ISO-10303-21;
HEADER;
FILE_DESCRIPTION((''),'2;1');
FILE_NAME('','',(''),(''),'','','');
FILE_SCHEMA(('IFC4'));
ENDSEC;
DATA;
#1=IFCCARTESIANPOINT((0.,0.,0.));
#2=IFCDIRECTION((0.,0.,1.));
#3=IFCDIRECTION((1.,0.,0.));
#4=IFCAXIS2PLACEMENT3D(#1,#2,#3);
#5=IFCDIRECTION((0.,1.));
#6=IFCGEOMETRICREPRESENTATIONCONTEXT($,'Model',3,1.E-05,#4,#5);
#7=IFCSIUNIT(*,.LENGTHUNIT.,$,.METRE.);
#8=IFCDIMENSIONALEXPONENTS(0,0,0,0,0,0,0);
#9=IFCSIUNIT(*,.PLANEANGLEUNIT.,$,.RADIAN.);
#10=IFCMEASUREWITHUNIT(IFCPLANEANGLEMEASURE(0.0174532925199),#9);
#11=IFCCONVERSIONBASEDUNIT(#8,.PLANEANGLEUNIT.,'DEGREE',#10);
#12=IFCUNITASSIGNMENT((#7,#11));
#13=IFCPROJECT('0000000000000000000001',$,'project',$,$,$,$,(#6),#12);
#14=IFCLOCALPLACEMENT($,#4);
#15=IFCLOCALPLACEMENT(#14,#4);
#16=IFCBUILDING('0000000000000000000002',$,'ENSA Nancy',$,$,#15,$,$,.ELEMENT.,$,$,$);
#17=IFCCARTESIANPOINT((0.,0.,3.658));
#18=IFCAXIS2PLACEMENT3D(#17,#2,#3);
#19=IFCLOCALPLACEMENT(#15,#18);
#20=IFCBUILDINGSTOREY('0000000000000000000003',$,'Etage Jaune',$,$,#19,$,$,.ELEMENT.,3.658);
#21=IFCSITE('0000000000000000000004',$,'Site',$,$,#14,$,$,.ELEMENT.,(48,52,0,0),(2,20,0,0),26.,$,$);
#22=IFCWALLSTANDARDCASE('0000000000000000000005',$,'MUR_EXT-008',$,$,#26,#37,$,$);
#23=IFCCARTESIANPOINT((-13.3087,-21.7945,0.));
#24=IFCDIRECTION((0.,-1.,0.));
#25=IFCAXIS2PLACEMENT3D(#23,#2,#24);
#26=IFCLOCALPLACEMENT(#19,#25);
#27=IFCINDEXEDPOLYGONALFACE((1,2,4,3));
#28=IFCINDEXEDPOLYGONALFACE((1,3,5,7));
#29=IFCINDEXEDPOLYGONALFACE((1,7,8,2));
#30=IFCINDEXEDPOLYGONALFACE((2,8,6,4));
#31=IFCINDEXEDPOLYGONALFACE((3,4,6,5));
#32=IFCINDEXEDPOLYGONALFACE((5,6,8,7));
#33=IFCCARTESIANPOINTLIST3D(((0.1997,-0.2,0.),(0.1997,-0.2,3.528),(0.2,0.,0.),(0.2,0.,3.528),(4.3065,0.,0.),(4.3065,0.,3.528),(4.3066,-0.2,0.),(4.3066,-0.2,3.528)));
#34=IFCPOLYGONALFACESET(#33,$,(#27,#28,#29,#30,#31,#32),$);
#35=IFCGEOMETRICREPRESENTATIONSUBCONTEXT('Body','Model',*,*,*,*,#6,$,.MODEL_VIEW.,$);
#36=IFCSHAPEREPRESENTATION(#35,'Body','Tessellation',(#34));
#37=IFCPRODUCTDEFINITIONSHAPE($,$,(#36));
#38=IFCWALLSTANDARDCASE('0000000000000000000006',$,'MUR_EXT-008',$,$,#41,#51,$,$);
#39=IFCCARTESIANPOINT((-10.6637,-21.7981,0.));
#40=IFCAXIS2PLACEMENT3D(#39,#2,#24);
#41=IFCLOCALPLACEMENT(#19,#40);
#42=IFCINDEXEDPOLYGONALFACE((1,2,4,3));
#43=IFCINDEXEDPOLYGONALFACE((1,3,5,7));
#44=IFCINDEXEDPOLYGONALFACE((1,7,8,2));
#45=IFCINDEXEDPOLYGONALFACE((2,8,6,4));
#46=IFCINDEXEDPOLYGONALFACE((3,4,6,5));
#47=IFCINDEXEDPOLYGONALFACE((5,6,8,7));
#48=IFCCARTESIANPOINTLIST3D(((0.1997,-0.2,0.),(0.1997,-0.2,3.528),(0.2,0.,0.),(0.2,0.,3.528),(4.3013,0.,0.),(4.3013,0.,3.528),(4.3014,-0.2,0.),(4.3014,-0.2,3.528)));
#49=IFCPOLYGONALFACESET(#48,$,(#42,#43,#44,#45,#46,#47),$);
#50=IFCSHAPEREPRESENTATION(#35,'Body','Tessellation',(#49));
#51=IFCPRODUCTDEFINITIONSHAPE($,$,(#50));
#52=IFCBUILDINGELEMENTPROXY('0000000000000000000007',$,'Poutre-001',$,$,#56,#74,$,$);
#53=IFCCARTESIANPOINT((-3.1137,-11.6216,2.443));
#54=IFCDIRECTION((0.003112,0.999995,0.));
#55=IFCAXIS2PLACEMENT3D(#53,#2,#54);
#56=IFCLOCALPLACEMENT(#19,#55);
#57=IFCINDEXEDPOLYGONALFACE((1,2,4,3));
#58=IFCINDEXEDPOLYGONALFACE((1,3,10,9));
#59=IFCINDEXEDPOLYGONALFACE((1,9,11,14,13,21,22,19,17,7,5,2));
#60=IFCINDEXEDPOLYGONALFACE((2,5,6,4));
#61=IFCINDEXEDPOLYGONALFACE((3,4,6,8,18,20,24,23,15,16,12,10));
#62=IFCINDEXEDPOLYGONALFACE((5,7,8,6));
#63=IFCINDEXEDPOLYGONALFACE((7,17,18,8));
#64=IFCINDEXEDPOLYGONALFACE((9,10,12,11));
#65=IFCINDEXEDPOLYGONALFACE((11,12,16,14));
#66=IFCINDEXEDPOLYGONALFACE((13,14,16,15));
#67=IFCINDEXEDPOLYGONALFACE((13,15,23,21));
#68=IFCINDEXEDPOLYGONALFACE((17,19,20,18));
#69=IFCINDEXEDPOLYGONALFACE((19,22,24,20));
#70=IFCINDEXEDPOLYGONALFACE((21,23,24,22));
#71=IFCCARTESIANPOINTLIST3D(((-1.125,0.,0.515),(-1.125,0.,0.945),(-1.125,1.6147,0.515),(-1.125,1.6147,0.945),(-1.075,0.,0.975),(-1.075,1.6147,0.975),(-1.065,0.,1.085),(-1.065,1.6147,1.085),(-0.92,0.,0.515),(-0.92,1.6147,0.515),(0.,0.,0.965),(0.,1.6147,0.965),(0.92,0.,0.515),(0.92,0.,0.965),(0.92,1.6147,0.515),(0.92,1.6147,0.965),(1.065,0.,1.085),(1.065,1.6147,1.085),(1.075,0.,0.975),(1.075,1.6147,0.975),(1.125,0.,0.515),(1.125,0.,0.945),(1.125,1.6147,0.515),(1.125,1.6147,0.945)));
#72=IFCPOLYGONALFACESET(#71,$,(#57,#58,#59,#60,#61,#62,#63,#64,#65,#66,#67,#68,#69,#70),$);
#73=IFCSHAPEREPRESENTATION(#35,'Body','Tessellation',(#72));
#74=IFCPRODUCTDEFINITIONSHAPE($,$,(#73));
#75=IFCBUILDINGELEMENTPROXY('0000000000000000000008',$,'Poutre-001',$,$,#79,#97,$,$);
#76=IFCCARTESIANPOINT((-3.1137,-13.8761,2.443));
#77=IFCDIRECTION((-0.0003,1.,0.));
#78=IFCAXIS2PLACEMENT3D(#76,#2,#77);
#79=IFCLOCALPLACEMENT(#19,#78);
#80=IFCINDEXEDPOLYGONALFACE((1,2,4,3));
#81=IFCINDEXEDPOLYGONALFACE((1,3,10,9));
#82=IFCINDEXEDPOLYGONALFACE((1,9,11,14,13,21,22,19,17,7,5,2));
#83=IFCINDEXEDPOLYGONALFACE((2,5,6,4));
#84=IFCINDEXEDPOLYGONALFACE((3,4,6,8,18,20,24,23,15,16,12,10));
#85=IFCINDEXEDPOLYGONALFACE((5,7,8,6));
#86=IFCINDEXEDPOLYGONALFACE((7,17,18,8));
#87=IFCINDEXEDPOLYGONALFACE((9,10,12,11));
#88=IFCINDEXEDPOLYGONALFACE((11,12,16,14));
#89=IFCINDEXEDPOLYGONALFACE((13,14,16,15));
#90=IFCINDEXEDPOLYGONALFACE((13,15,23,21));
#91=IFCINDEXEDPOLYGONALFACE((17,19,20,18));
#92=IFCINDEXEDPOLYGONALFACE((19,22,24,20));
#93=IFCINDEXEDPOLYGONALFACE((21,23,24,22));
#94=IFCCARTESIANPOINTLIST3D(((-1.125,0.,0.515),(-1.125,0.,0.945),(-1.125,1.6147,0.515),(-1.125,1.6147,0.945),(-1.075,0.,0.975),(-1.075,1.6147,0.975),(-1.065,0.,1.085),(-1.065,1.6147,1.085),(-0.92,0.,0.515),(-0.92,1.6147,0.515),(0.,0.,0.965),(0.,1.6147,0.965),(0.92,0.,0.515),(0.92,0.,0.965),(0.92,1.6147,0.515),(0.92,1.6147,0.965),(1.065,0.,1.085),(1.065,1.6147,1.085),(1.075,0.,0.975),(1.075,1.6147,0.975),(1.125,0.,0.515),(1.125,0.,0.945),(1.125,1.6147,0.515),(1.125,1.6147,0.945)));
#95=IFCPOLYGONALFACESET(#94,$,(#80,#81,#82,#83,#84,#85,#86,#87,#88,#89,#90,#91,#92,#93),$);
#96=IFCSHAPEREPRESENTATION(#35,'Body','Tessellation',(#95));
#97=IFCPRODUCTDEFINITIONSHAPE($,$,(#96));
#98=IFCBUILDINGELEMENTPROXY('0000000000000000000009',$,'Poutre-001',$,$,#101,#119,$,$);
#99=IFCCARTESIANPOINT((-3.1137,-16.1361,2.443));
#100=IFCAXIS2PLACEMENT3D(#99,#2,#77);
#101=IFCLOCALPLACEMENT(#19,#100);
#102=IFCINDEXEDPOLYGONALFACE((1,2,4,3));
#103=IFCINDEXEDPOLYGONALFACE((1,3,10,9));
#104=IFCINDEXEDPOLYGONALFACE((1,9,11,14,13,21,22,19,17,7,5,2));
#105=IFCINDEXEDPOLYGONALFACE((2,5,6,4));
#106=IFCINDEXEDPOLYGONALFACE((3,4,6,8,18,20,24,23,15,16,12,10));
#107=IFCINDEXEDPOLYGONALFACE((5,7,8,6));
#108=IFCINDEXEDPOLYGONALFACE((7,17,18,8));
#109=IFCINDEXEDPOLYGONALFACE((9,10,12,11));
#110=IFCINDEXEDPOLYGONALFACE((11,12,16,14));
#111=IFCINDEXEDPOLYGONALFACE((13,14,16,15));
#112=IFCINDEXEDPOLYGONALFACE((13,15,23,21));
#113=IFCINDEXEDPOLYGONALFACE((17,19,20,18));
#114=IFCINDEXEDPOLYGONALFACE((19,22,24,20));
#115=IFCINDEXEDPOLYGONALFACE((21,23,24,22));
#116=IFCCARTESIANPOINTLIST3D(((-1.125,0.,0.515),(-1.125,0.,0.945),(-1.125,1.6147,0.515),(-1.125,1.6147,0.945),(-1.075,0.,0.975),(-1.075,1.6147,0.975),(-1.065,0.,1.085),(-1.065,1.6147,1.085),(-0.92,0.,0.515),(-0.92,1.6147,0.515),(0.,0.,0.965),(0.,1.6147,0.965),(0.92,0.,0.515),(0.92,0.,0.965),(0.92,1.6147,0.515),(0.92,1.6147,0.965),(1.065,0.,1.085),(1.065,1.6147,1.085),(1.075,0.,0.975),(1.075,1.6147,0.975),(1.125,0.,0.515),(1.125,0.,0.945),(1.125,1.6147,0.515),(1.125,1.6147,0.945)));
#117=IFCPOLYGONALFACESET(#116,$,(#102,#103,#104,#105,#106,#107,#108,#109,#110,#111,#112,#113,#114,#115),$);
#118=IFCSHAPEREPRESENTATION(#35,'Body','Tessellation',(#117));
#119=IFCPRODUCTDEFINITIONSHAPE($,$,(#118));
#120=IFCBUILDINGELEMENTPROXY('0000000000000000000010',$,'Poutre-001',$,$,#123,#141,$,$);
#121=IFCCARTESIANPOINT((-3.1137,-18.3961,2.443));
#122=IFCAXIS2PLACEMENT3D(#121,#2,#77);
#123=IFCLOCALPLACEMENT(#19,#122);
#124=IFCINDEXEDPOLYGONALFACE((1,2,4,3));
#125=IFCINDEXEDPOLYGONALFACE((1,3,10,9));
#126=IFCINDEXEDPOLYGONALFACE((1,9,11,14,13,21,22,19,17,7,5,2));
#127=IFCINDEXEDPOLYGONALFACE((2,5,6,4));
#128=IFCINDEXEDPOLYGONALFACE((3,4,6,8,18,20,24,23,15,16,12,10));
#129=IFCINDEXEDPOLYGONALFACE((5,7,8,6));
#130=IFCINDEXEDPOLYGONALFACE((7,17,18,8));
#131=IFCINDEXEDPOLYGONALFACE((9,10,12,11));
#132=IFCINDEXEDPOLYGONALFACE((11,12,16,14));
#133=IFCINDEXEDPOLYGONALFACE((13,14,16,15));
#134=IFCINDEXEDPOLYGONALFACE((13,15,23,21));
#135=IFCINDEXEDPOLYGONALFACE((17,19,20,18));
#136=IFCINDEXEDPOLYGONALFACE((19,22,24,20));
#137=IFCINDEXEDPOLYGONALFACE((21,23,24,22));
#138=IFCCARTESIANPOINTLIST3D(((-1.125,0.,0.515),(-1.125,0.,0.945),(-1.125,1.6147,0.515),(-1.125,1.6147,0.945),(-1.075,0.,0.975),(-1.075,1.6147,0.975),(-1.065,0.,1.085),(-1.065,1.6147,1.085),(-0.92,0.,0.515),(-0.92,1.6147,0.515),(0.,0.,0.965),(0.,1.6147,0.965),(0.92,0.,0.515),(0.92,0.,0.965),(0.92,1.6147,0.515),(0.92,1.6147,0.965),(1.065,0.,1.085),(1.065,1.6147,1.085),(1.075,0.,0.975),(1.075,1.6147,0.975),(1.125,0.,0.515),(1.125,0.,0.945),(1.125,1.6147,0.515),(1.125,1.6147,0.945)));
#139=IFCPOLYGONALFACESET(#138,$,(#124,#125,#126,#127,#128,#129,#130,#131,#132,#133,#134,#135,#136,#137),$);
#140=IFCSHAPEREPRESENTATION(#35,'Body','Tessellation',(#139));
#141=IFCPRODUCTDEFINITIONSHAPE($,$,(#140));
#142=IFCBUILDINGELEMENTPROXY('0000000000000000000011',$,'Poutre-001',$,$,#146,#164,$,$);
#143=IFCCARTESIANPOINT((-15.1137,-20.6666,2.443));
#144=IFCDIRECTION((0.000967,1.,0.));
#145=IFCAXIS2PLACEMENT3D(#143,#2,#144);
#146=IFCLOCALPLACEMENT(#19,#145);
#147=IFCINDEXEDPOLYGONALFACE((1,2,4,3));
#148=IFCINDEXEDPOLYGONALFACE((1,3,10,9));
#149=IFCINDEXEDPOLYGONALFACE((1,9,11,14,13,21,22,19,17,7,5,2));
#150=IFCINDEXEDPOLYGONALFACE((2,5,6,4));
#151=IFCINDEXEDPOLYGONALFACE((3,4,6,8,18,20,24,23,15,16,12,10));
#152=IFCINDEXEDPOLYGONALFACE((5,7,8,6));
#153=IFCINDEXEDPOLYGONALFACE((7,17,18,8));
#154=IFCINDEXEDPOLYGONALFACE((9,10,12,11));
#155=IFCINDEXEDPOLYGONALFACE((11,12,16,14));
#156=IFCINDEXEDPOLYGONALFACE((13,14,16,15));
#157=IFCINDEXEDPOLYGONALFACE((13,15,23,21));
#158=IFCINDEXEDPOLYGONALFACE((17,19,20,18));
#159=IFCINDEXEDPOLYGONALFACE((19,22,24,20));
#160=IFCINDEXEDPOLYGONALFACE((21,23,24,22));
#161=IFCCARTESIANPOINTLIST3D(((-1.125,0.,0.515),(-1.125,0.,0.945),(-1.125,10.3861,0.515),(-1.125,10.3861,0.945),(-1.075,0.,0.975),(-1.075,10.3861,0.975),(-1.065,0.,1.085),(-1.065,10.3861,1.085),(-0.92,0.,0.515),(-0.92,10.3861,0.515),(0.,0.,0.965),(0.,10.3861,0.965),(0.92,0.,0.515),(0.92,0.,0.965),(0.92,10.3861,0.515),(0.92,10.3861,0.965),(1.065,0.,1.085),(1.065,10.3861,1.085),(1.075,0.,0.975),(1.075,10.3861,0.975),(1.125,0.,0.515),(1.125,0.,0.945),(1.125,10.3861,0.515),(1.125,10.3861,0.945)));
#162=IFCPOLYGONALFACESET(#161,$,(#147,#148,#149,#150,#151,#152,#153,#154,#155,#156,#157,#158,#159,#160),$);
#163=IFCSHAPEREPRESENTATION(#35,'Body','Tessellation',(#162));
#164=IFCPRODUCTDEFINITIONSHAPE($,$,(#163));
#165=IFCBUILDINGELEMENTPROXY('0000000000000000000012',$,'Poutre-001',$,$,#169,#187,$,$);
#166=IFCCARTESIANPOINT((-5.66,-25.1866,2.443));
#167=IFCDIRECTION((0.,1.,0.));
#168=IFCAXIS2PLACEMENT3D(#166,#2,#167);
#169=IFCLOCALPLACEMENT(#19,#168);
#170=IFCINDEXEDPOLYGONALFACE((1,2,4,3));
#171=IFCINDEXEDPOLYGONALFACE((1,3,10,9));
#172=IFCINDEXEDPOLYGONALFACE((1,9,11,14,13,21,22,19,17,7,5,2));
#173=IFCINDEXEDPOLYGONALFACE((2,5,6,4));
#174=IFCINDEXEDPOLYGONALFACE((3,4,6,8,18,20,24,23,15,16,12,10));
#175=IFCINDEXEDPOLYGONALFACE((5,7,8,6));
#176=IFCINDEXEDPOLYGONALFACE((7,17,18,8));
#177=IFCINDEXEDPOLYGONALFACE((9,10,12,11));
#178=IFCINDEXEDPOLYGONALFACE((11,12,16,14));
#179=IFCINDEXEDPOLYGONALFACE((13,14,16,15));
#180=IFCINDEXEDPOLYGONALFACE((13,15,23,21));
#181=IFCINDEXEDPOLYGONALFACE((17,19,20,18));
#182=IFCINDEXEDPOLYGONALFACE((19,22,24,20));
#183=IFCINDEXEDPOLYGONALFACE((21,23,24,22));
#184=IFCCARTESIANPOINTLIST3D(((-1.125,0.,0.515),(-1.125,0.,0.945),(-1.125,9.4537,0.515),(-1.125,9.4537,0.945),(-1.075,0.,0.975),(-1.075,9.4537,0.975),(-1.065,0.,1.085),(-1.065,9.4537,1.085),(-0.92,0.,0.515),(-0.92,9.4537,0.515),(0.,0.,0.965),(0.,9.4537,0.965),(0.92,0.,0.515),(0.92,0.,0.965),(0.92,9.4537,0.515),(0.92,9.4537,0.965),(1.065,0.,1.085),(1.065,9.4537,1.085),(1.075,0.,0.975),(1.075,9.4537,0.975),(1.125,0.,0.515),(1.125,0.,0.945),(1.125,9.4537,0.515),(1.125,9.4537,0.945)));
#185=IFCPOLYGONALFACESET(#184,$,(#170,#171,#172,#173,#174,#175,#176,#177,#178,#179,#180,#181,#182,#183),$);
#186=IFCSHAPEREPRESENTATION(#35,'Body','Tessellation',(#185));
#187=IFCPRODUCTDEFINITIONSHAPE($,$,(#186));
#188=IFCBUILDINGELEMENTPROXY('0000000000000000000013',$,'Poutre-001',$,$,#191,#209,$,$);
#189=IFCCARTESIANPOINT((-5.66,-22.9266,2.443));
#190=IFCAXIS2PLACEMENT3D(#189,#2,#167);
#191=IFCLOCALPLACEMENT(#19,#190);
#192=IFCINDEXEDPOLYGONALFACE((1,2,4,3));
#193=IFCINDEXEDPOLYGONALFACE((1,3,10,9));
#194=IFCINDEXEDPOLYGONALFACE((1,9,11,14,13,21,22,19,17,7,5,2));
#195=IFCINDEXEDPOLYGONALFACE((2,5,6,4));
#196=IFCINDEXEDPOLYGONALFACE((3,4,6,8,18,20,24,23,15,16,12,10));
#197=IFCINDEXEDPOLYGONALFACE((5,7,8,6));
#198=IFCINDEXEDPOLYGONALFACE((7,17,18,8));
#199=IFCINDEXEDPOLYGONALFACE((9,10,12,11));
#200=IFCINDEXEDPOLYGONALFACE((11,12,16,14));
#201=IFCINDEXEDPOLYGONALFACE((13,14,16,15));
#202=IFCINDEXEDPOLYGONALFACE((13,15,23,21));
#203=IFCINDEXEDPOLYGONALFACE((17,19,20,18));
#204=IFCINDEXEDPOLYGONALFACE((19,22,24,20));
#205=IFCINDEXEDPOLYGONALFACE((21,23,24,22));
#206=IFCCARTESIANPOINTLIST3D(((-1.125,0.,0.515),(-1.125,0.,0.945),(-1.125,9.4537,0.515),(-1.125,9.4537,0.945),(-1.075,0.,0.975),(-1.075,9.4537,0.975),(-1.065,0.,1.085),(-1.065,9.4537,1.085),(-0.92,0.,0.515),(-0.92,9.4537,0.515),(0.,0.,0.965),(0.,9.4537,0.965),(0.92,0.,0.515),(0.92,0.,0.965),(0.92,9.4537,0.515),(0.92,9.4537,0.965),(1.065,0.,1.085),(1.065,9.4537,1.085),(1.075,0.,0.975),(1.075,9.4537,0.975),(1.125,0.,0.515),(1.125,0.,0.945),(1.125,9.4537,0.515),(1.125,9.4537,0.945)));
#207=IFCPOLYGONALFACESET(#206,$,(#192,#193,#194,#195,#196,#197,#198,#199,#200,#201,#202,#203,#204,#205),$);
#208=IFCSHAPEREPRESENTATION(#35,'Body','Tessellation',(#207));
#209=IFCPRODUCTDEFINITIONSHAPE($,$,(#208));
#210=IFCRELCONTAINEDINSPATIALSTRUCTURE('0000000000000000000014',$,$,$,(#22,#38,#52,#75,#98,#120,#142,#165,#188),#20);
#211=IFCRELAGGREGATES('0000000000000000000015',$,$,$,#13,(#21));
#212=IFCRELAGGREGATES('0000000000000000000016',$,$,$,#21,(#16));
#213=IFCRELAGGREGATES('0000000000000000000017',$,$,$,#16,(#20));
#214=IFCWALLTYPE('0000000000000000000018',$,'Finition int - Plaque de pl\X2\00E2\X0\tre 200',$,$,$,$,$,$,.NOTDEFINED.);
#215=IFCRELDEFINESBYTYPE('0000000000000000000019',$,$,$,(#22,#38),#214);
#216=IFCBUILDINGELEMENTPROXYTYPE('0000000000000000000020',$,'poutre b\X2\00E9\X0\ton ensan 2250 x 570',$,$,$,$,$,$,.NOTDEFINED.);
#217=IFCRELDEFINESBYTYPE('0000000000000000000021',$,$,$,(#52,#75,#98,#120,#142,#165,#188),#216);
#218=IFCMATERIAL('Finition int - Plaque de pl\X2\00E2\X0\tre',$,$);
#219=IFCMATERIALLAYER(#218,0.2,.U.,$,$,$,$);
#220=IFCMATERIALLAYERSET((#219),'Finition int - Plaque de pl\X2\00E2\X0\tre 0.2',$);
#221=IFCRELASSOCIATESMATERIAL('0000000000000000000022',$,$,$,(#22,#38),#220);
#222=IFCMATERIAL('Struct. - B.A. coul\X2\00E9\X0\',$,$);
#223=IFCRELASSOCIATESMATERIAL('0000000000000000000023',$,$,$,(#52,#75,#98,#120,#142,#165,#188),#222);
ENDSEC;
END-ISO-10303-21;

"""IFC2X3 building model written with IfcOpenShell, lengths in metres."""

from ifc_helpers import new_model, entity, si_unit, converted_unit, direction, frame, origin_with_axes, place, context, subcontext, project, spatial, polyline, outline, extrude, material, layer, layer_set, layer_usage, type_object, element, save


model = new_model("IFC2X3")

# Units and contexts
model_context = context("Model", 3, precision=1e-05, world=origin_with_axes(), true_north=direction((0.0, 1.0)))
body_context = subcontext(model_context, "Body", "Model", "MODEL_VIEW")
ifc_project = project(units=[si_unit("LENGTHUNIT", "METRE"), converted_unit("PLANEANGLEUNIT", "DEGREE", entity("IfcPlaneAngleMeasure", 0.0174532925199), si_unit("PLANEANGLEUNIT", "RADIAN"), dimensions=[0, 0, 0, 0, 0, 0, 0])], contexts=[model_context])

# Site, building, storey
site_placement = place(None, origin_with_axes())
site = spatial("IfcSite", under=ifc_project, at=site_placement, Name="Site", CompositionType="ELEMENT", RefLatitude=(48, 52, 0, 0), RefLongitude=(2, 20, 0, 0), RefElevation=26.0)
building_placement = place(site_placement, origin_with_axes())
building = spatial("IfcBuilding", under=site, at=building_placement, Name="ENSA Nancy", CompositionType="ELEMENT")
storey_placement = place(building_placement, frame((0.0, 0.0, 3.658), z_axis=(0.0, 0.0, 1.0), x_axis=(1.0, 0.0, 0.0)))
storey = spatial("IfcBuildingStorey", under=building, at=storey_placement, Name="Etage Jaune", CompositionType="ELEMENT", Elevation=3.658)

# Shared definitions
ifc_material_1 = material(Name="Finition int - Plaque de plâtre")
ifc_layer_1 = layer(ifc_material_1, 0.2, ventilated="UNKNOWN")
ifc_layer_set_1 = layer_set([ifc_layer_1], Name="Finition int - Plaque de plâtre 0.2")
wall_type_1 = type_object("IfcWallType", Name="Finition int - Plaque de plâtre 200", PredefinedType="NOTDEFINED")

# Walls
ifc_layer_usage_1 = layer_usage(ifc_layer_set_1, "AXIS2", "NEGATIVE", 0.0)
wall_1_placement = place(storey_placement, frame((-13.3087, -21.7945, 0.0), z_axis=(0.0, 0.0, 1.0), x_axis=(0.0, -1.0, 0.0)))
element("IfcWallStandardCase", 1, at=wall_1_placement, inside=storey, type_object=wall_type_1, material=ifc_layer_usage_1, Name="MUR_EXT-008", context=body_context, shape_type="SweptSolid", body=[
    extrude(outline(polyline([(0.1997, -0.2), (4.3066, -0.2), (4.3065, 0.0), (0.2, 0.0), (0.1997, -0.2)])), origin_with_axes(), (0.0, 0.0, 1.0), 3.528),
])
ifc_layer_usage_2 = layer_usage(ifc_layer_set_1, "AXIS2", "NEGATIVE", 0.0)
wall_2_placement = place(storey_placement, frame((-10.6637, -21.7981, 0.0), z_axis=(0.0, 0.0, 1.0), x_axis=(0.0, -1.0, 0.0)))
element("IfcWallStandardCase", 2, at=wall_2_placement, inside=storey, type_object=wall_type_1, material=ifc_layer_usage_2, Name="MUR_EXT-008", context=body_context, shape_type="SweptSolid", body=[
    extrude(outline(polyline([(0.1997, -0.2), (4.3014, -0.2), (4.3013, 0.0), (0.2, 0.0), (0.1997, -0.2)])), origin_with_axes(), (0.0, 0.0, 1.0), 3.528),
])

# Building element proxies
ifc_material_2 = material(Name="Struct. - B.A. coulé")
building_element_proxy_type_1 = type_object("IfcBuildingElementProxyType", Name="poutre béton ensan 2250 x 570", PredefinedType="NOTDEFINED")
proxy_1_placement = place(storey_placement, frame((-3.1137, -11.6216, 2.443), z_axis=(0.0, 0.0, 1.0), x_axis=(0.003112, 0.999995, 0.0)))
element("IfcBuildingElementProxy", 3, at=proxy_1_placement, inside=storey, type_object=building_element_proxy_type_1, material=ifc_material_2, Name="Poutre-001", context=body_context, shape_type="SweptSolid", body=[
    extrude(outline(polyline([(-1.065, 1.085), (-1.075, 0.975), (-1.125, 0.945), (-1.125, 0.515), (-0.92, 0.515), (0.0, 0.965), (0.92, 0.965), (0.92, 0.515), (1.125, 0.515), (1.125, 0.945), (1.075, 0.975), (1.065, 1.085), (-1.065, 1.085)])), frame((0.0, 1.6147, 0.0), z_axis=(0.0, -1.0, 0.0), x_axis=(1.0, 0.0, 0.0)), (0.0, 0.0, 1.0), 1.6147),
])
for number, where, z_axis, x_axis, name in (
    (4, (-3.1137, -13.8761, 2.443), (0.0, 0.0, 1.0), (-0.0003, 1.0, 0.0), "Poutre-001"),
    (5, (-3.1137, -16.1361, 2.443), (0.0, 0.0, 1.0), (-0.0003, 1.0, 0.0), "Poutre-001"),
    (6, (-3.1137, -18.3961, 2.443), (0.0, 0.0, 1.0), (-0.0003, 1.0, 0.0), "Poutre-001"),
):
    element("IfcBuildingElementProxy", number, at=place(storey_placement, frame(where, z_axis=z_axis, x_axis=x_axis)), inside=storey, type_object=building_element_proxy_type_1, material=ifc_material_2, Name=name, context=body_context, shape_type="SweptSolid", body=[
        extrude(outline(polyline([(-1.065, 1.085), (-1.075, 0.975), (-1.125, 0.945), (-1.125, 0.515), (-0.92, 0.515), (0.0, 0.965), (0.92, 0.965), (0.92, 0.515), (1.125, 0.515), (1.125, 0.945), (1.075, 0.975), (1.065, 1.085), (-1.065, 1.085)])), frame((0.0, 1.6147, 0.0), z_axis=(0.0, -1.0, 0.0), x_axis=(1.0, 0.0, 0.0)), (0.0, 0.0, 1.0), 1.6147),
    ])
proxy_2_placement = place(storey_placement, frame((-15.1137, -20.6666, 2.443), z_axis=(0.0, 0.0, 1.0), x_axis=(0.000967, 1.0, 0.0)))
element("IfcBuildingElementProxy", 7, at=proxy_2_placement, inside=storey, type_object=building_element_proxy_type_1, material=ifc_material_2, Name="Poutre-001", context=body_context, shape_type="SweptSolid", body=[
    extrude(outline(polyline([(-1.065, 1.085), (-1.075, 0.975), (-1.125, 0.945), (-1.125, 0.515), (-0.92, 0.515), (0.0, 0.965), (0.92, 0.965), (0.92, 0.515), (1.125, 0.515), (1.125, 0.945), (1.075, 0.975), (1.065, 1.085), (-1.065, 1.085)])), frame((0.0, 10.3861, 0.0), z_axis=(0.0, -1.0, 0.0), x_axis=(1.0, 0.0, 0.0)), (0.0, 0.0, 1.0), 10.3861),
])
for number, where, z_axis, x_axis, name in (
    (8, (-5.66, -25.1866, 2.443), (0.0, 0.0, 1.0), (0.0, 1.0, 0.0), "Poutre-001"),
    (9, (-5.66, -22.9266, 2.443), (0.0, 0.0, 1.0), (0.0, 1.0, 0.0), "Poutre-001"),
):
    element("IfcBuildingElementProxy", number, at=place(storey_placement, frame(where, z_axis=z_axis, x_axis=x_axis)), inside=storey, type_object=building_element_proxy_type_1, material=ifc_material_2, Name=name, context=body_context, shape_type="SweptSolid", body=[
        extrude(outline(polyline([(-1.065, 1.085), (-1.075, 0.975), (-1.125, 0.945), (-1.125, 0.515), (-0.92, 0.515), (0.0, 0.965), (0.92, 0.965), (0.92, 0.515), (1.125, 0.515), (1.125, 0.945), (1.075, 0.975), (1.065, 1.085), (-1.065, 1.085)])), frame((0.0, 9.4537, 0.0), z_axis=(0.0, -1.0, 0.0), x_axis=(1.0, 0.0, 0.0)), (0.0, 0.0, 1.0), 9.4537),
    ])

save(model, "model.ifc")
